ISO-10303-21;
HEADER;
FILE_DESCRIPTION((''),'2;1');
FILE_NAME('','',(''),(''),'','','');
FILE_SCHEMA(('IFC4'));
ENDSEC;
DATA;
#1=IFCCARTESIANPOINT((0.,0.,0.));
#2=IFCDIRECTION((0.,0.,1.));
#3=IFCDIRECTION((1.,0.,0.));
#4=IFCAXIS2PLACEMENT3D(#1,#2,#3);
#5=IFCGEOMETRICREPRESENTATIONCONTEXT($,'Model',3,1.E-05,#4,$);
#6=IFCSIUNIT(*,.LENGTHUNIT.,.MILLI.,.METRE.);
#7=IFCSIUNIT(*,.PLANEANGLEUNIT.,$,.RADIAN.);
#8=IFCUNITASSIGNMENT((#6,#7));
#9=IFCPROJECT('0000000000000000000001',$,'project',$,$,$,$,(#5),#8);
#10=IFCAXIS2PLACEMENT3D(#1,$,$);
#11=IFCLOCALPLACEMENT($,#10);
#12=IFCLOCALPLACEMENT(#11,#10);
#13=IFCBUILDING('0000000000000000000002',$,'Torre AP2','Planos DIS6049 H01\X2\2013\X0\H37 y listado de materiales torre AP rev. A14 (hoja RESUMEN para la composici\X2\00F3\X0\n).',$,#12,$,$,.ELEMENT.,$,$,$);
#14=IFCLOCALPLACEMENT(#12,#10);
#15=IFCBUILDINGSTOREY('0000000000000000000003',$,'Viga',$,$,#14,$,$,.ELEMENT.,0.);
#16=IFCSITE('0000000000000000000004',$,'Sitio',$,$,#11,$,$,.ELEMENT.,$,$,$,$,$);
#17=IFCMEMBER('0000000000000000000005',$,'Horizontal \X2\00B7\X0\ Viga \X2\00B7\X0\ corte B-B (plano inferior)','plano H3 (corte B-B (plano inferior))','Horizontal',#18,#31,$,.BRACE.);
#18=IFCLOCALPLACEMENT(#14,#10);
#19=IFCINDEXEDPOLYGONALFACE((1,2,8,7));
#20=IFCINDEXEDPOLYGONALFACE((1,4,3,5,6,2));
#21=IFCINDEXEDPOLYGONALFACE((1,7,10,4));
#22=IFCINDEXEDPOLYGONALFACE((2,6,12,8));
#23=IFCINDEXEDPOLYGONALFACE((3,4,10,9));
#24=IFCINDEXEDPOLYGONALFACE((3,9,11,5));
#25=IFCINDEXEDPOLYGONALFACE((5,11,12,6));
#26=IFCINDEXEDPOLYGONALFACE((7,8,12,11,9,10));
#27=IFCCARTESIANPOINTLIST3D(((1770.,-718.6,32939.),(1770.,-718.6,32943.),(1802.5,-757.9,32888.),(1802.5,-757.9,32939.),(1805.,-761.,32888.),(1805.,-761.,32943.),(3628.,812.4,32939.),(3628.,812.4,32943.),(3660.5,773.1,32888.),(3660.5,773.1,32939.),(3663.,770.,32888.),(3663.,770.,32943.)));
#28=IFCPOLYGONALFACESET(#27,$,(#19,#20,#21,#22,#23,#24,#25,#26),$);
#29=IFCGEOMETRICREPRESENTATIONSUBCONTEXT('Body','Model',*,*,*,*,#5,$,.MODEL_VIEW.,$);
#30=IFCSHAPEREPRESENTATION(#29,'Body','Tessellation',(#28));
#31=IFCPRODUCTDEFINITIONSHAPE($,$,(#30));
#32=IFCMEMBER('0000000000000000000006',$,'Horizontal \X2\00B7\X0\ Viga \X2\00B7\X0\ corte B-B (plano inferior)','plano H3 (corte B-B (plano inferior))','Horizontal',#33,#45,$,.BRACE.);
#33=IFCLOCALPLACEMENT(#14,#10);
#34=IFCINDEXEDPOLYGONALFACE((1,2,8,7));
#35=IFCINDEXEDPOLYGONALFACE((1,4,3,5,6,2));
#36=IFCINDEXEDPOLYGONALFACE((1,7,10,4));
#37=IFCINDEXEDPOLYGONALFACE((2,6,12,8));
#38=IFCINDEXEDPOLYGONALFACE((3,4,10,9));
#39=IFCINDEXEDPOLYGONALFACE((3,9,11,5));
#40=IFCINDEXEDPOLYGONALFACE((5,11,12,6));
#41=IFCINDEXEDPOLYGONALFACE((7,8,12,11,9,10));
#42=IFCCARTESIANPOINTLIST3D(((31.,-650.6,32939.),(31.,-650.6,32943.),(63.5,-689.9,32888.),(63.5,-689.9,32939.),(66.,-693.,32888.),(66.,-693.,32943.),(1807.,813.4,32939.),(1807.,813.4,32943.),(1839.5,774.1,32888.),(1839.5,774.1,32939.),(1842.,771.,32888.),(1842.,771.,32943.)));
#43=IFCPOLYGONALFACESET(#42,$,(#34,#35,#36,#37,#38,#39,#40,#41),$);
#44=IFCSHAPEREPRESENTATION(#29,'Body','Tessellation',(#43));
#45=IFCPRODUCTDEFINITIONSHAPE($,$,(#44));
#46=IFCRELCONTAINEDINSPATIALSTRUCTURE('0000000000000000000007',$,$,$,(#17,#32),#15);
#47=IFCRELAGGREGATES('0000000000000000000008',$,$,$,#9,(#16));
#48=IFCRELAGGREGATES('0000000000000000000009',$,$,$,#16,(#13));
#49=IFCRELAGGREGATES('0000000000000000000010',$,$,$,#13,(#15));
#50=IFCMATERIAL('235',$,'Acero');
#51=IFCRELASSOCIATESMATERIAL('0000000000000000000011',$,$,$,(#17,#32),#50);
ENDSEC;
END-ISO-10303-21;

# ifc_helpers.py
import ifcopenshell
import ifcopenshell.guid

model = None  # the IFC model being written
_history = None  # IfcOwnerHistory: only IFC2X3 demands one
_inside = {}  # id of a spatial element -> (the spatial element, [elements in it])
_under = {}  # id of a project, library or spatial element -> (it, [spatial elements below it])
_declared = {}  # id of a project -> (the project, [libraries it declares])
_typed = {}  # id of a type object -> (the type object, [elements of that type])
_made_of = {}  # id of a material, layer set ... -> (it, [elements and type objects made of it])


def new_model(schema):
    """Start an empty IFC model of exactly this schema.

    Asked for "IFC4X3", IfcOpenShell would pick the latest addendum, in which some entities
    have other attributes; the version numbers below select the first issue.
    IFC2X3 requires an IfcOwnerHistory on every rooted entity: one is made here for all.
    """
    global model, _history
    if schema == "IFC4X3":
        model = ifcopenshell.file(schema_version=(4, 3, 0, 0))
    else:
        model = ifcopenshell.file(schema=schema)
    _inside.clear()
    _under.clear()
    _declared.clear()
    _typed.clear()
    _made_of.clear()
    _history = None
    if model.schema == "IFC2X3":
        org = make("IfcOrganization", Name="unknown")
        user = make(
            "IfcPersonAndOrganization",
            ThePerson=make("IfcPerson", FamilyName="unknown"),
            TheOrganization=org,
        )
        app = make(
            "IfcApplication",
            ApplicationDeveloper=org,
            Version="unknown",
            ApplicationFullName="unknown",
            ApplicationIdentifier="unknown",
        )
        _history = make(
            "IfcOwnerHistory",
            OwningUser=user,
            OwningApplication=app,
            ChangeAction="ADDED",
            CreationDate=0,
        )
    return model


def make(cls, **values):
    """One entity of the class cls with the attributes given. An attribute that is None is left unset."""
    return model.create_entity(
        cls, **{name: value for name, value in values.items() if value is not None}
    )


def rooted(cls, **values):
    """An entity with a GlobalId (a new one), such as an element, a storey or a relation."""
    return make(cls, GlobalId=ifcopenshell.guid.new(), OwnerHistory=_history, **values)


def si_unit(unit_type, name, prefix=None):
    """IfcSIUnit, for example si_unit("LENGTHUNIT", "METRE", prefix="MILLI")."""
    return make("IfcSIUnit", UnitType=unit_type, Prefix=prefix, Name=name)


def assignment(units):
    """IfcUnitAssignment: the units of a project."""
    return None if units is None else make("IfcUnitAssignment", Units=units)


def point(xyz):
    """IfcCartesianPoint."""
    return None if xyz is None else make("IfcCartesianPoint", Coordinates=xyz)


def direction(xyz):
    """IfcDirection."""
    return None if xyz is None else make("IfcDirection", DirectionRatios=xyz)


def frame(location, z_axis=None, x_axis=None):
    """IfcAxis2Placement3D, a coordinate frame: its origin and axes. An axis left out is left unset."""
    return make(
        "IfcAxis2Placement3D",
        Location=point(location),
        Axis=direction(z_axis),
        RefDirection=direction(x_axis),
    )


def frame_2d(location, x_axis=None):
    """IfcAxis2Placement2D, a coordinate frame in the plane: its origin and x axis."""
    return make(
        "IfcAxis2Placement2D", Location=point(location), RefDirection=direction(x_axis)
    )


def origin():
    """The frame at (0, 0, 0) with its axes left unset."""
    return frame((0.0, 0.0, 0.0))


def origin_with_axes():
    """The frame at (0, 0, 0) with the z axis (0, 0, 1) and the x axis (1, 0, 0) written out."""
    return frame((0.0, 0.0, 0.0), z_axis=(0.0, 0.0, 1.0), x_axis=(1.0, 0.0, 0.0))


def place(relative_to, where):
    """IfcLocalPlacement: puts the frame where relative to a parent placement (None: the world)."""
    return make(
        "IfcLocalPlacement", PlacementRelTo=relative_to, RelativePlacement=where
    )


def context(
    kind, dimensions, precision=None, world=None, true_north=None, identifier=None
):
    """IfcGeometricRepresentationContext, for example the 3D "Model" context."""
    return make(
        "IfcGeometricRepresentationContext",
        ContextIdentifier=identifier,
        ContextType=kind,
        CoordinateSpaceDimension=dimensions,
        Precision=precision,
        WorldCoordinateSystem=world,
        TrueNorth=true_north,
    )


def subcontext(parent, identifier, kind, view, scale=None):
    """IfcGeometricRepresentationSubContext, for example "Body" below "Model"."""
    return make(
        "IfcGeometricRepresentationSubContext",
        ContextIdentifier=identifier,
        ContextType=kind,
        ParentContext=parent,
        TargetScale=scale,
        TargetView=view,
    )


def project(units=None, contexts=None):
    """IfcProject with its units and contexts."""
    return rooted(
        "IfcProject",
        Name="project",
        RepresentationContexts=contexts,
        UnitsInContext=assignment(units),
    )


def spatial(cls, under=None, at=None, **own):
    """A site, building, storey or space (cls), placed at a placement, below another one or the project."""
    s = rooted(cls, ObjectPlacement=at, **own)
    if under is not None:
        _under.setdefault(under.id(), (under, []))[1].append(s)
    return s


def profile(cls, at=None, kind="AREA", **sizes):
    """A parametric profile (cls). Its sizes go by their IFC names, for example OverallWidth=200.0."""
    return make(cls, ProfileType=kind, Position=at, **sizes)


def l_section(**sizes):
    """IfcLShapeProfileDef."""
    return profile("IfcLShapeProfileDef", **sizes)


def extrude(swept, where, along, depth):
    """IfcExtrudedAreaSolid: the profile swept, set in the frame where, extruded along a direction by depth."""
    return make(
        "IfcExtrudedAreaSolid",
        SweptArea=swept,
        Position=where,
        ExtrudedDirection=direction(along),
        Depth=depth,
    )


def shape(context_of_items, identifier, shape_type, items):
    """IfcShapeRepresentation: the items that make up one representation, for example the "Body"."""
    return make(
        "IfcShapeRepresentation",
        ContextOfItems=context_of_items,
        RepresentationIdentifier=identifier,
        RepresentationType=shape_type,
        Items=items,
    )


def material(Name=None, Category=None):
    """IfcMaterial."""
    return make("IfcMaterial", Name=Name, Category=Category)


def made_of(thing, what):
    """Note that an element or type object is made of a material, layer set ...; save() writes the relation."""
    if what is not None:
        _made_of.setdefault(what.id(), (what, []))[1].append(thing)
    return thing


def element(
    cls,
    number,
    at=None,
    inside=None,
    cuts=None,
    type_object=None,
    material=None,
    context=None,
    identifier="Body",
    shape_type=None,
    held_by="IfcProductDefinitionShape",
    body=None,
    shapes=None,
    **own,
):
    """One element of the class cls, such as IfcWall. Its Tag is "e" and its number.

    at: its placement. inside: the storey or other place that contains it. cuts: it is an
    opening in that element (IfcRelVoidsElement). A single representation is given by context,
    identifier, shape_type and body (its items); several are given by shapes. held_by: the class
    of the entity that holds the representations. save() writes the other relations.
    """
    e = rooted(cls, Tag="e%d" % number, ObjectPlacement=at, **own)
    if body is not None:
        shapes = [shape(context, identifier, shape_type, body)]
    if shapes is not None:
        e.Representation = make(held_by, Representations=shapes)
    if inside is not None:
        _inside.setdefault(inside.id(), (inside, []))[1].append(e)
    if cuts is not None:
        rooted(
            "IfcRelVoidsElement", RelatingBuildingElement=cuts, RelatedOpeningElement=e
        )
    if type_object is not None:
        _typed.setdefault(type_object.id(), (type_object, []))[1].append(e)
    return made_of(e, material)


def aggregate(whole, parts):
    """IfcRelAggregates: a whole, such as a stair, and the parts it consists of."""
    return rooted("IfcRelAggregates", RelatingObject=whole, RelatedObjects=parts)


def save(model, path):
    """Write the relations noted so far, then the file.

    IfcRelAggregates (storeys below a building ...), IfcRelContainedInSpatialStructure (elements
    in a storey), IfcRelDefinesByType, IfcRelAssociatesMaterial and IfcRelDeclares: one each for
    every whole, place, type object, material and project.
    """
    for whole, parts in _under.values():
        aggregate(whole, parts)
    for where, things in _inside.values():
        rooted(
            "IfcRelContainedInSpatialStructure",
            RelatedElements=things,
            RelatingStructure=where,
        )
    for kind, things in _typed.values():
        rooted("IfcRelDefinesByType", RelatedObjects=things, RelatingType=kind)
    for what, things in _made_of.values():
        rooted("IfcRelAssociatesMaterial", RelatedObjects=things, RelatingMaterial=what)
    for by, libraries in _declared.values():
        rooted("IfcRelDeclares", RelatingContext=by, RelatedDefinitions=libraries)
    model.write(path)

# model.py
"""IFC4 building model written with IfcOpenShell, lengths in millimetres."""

from ifc_helpers import new_model, si_unit, frame, frame_2d, origin, origin_with_axes, place, context, subcontext, project, spatial, l_section, extrude, material, element, save


model = new_model("IFC4")

# Units and contexts
model_context = context("Model", 3, precision=1e-05, world=origin_with_axes())
body_context = subcontext(model_context, "Body", "Model", "MODEL_VIEW")
ifc_project = project(units=[si_unit("LENGTHUNIT", "METRE", prefix="MILLI"), si_unit("PLANEANGLEUNIT", "RADIAN")], contexts=[model_context])

# Site, building, storey
site_placement = place(None, origin())
site = spatial("IfcSite", under=ifc_project, at=site_placement, Name="Sitio", CompositionType="ELEMENT")
building_placement = place(site_placement, origin())
building = spatial("IfcBuilding", under=site, at=building_placement, Name="Torre AP2", Description="Planos DIS6049 H01–H37 y listado de materiales torre AP rev. A14 (hoja RESUMEN para la composición).", CompositionType="ELEMENT")
storey_placement = place(building_placement, origin())
storey = spatial("IfcBuildingStorey", under=building, at=storey_placement, Name="Viga", CompositionType="ELEMENT", Elevation=0.0)

# Members
ifc_material = material(Name="235", Category="Acero")
member_1_placement = place(storey_placement, frame((3663.0, 770.0, 32943.0), z_axis=(-0.77175, -0.635926, 0.0), x_axis=(-0.635926, 0.77175, 0.0)))
element("IfcMember", 1, at=member_1_placement, inside=storey, material=ifc_material, Name="Horizontal · Viga · corte B-B (plano inferior)", Description="plano H3 (corte B-B (plano inferior))", ObjectType="Horizontal", PredefinedType="BRACE", context=body_context, shape_type="SweptSolid", body=[
    extrude(l_section(Depth=55.0, Width=55.0, Thickness=4.0, at=frame_2d((27.5, 27.5))), None, (0.0, 0.0, 1.0), 2407.5),
])
member_2_placement = place(storey_placement, frame((1842.0, 771.0, 32943.0), z_axis=(-0.771629, -0.636073, 0.0), x_axis=(-0.636073, 0.771629, 0.0)))
element("IfcMember", 2, at=member_2_placement, inside=storey, material=ifc_material, Name="Horizontal · Viga · corte B-B (plano inferior)", Description="plano H3 (corte B-B (plano inferior))", ObjectType="Horizontal", PredefinedType="BRACE", context=body_context, shape_type="SweptSolid", body=[
    extrude(l_section(Depth=55.0, Width=55.0, Thickness=4.0, at=frame_2d((27.5, 27.5))), None, (0.0, 0.0, 1.0), 2301.6),
])

save(model, "model.ifc")
